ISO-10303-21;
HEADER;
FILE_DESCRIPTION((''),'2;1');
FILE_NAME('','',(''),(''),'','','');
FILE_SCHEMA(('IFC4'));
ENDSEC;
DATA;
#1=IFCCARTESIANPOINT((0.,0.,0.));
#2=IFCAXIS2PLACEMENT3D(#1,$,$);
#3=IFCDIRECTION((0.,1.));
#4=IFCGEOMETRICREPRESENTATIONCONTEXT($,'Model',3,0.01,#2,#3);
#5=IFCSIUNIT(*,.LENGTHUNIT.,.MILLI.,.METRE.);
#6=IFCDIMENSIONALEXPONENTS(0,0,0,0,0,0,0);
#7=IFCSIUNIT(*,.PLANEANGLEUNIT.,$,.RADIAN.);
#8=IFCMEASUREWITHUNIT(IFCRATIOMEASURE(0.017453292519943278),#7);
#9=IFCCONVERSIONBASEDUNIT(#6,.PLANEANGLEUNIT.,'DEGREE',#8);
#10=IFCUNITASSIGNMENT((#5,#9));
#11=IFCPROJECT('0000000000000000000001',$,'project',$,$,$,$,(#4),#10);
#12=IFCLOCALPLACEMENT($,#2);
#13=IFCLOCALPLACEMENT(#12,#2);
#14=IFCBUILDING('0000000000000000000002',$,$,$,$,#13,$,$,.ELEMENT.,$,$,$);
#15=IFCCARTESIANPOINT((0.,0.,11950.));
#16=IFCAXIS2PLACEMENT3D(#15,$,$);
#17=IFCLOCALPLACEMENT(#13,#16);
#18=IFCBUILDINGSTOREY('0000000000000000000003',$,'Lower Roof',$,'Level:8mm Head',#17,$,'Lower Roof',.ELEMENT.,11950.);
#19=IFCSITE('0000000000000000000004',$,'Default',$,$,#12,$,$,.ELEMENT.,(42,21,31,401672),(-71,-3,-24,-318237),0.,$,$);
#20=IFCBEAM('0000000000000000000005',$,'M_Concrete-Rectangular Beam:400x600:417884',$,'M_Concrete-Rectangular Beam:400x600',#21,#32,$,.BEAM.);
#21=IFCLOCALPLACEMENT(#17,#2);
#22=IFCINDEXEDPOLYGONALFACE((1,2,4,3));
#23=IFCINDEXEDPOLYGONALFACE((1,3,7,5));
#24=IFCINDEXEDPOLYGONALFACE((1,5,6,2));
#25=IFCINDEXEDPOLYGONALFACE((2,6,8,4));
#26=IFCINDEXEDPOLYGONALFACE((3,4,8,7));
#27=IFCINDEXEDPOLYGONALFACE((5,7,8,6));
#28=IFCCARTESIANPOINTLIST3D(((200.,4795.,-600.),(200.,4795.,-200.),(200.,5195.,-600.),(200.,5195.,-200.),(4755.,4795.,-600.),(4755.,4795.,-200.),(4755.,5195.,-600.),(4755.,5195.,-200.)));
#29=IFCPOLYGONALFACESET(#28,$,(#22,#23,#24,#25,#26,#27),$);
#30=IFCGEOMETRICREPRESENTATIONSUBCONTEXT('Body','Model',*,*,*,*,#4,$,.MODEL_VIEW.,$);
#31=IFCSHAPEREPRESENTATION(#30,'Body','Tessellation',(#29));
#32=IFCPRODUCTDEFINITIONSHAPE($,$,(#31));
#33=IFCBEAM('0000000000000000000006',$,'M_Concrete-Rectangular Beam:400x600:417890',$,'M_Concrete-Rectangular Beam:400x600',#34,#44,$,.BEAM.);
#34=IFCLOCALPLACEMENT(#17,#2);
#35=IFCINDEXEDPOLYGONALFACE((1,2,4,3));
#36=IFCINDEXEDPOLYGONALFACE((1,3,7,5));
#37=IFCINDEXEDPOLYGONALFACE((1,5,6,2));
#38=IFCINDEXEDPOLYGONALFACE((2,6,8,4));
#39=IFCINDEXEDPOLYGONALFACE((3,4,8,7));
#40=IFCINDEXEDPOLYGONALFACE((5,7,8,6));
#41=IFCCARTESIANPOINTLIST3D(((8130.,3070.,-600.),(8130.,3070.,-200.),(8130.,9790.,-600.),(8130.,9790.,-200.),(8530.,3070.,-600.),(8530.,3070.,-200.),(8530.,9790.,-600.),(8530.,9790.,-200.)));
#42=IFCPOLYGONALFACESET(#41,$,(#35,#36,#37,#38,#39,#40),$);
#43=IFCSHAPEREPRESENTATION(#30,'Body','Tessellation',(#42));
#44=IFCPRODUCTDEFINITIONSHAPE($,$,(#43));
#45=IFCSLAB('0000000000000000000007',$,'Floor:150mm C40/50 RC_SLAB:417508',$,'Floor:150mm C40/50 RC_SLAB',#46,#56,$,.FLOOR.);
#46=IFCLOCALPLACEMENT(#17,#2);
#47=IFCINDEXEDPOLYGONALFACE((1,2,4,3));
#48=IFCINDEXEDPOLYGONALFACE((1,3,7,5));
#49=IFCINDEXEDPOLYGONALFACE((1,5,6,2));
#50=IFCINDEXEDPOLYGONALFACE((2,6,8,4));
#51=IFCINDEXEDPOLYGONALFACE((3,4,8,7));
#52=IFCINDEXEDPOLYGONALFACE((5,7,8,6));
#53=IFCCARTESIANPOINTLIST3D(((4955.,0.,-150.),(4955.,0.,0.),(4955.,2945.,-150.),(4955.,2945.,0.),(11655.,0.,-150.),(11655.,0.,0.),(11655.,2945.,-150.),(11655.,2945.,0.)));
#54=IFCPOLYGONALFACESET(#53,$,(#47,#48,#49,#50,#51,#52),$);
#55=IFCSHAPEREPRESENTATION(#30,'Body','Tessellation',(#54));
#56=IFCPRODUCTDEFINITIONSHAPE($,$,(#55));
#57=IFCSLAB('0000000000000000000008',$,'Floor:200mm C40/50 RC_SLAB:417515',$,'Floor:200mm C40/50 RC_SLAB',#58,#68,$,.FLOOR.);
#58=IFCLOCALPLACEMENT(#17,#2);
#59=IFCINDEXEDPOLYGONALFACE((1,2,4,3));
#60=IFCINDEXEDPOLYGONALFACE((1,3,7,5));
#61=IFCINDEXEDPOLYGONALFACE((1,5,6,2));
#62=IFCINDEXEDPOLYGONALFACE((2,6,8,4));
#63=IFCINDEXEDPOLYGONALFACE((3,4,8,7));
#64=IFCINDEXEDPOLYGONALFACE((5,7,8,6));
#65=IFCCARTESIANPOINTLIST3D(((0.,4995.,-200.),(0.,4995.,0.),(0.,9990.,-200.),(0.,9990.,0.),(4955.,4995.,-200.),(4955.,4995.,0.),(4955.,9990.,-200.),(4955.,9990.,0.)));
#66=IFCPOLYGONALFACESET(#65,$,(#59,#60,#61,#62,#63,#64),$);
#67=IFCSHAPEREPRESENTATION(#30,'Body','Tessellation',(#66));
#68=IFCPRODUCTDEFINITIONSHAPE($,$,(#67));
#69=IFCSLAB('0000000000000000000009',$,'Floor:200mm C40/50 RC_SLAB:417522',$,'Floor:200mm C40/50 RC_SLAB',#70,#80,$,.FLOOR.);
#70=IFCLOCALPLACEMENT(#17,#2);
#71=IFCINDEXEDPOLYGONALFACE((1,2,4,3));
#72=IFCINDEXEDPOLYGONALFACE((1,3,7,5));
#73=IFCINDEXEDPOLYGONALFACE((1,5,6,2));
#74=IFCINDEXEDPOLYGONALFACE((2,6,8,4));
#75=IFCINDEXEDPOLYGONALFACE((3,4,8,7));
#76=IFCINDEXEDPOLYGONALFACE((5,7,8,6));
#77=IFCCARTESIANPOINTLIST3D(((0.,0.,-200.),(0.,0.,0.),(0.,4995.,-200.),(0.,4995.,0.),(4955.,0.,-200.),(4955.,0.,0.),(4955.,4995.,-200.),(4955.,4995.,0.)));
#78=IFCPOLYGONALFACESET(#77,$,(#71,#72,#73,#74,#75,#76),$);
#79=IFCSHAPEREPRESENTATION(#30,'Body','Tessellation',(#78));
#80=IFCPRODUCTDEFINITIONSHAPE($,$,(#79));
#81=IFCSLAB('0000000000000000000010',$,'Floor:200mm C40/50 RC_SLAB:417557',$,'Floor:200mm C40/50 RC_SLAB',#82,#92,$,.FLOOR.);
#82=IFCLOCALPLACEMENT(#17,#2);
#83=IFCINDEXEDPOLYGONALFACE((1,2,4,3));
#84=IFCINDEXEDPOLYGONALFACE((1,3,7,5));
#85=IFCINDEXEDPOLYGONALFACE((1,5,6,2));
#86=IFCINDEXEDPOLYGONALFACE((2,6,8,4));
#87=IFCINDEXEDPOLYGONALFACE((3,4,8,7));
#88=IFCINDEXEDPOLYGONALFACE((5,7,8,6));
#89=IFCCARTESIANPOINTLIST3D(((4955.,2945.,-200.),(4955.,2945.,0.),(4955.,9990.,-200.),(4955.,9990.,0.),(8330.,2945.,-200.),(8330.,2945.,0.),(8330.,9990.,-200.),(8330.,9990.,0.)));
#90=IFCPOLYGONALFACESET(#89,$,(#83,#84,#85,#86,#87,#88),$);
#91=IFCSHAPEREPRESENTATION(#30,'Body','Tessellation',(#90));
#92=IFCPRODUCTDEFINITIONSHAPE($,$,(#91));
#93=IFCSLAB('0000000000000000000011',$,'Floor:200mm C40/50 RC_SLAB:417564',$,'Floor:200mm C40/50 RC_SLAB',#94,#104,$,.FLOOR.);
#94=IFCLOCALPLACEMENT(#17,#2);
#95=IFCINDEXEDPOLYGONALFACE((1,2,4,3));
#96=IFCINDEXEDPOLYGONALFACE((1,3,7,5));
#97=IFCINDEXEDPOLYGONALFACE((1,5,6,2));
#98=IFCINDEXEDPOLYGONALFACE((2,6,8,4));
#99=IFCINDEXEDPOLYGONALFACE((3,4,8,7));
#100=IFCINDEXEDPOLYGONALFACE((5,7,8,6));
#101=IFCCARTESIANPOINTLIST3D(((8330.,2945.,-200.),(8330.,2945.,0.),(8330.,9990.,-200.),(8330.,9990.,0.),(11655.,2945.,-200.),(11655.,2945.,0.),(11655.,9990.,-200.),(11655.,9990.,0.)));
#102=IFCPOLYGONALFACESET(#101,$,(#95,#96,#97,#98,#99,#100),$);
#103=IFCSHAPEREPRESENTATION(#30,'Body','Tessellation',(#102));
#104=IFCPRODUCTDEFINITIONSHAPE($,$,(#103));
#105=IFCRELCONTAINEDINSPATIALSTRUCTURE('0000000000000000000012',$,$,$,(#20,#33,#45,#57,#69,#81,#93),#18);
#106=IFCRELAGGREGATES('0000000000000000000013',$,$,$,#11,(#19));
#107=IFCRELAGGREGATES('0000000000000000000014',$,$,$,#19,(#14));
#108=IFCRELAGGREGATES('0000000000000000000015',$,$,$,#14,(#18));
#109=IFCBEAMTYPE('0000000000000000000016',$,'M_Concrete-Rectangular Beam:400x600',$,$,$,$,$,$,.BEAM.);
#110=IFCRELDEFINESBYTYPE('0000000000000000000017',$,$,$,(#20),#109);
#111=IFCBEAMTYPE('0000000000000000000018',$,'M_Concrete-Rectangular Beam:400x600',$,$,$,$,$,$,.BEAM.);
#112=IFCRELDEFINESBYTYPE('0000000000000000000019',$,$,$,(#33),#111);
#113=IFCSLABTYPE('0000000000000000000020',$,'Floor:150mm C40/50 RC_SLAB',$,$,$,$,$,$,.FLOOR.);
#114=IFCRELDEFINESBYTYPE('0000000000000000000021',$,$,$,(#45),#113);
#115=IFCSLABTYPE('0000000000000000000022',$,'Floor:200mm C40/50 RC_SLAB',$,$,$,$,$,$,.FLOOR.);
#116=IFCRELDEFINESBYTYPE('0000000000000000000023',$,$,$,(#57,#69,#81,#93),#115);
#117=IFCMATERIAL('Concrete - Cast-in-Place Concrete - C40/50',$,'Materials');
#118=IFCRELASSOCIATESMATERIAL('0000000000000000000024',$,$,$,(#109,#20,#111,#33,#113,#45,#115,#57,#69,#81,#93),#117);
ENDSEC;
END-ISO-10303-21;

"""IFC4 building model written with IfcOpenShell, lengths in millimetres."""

from ifc_helpers import new_model, entity, si_unit, converted_unit, direction, frame, origin, place, context, subcontext, project, spatial, indexed_curve, outline, extrude, source, transform, mapped, material, type_object, type_shapes, element, save


model = new_model("IFC4")

# Units and contexts
model_context = context("Model", 3, precision=0.01, world=origin(), true_north=direction((0.0, 1.0)))
body_context = subcontext(model_context, "Body", "Model", "MODEL_VIEW")
ifc_project = project(units=[si_unit("LENGTHUNIT", "METRE", prefix="MILLI"), converted_unit("PLANEANGLEUNIT", "DEGREE", entity("IfcRatioMeasure", 0.017453292519943278), si_unit("PLANEANGLEUNIT", "RADIAN"), dimensions=[0, 0, 0, 0, 0, 0, 0])], contexts=[model_context])

# Site, building, storey
site_placement = place(None, origin())
site = spatial("IfcSite", under=ifc_project, at=site_placement, Name="Default", CompositionType="ELEMENT", RefLatitude=(42, 21, 31, 401672), RefLongitude=(-71, -3, -24, -318237), RefElevation=0.0)
building_placement = place(site_placement, origin())
building = spatial("IfcBuilding", under=site, at=building_placement, CompositionType="ELEMENT")
storey_placement = place(building_placement, frame((0.0, 0.0, 11950.0)))
storey = spatial("IfcBuildingStorey", under=building, at=storey_placement, Name="Lower Roof", ObjectType="Level:8mm Head", LongName="Lower Roof", CompositionType="ELEMENT", Elevation=11950.0)

# Beams
ifc_material = material(Name="Concrete - Cast-in-Place Concrete - C40/50", Category="Materials")
beam_type_1 = type_object("IfcBeamType", Name="M_Concrete-Rectangular Beam:400x600", PredefinedType="BEAM", material=ifc_material)
shared_shape_1 = source(origin(), body_context, "Body", "SweptSolid", [
    extrude(outline(indexed_curve([(-200.0, -200.0), (200.0, -200.0), (200.0, 200.0), (-200.0, 200.0), (-200.0, -200.0)], self_intersect=False)), frame((200.0, 4995.0, 11550.0), z_axis=(1.0, 0.0, 0.0), x_axis=(0.0, 0.0, -1.0)), (0.0, 0.0, 1.0), 4555.0),
])
type_shapes(beam_type_1, [shared_shape_1])
beam_1_placement = place(storey_placement, frame((0.0, 0.0, -11950.0)))
element("IfcBeam", 1, at=beam_1_placement, inside=storey, type_object=beam_type_1, material=ifc_material, Name="M_Concrete-Rectangular Beam:400x600:417884", ObjectType="M_Concrete-Rectangular Beam:400x600", PredefinedType="BEAM", context=body_context, shape_type="MappedRepresentation", body=[
    mapped(shared_shape_1, transform((0.0, 0.0, 0.0), scale=1.0)),
])
beam_type_2 = type_object("IfcBeamType", Name="M_Concrete-Rectangular Beam:400x600", PredefinedType="BEAM", material=ifc_material)
shared_shape_2 = source(origin(), body_context, "Body", "SweptSolid", [
    extrude(outline(indexed_curve([(-200.0, -200.0), (200.0, -200.0), (200.0, 200.0), (-200.0, 200.0), (-200.0, -200.0)], self_intersect=False)), frame((8330.0, 3070.0, 11550.0), z_axis=(0.0, 1.0, 0.0), x_axis=(-1.0, 0.0, 0.0)), (0.0, 0.0, 1.0), 6720.0),
])
type_shapes(beam_type_2, [shared_shape_2])
beam_2_placement = place(storey_placement, frame((0.0, 0.0, -11950.0)))
element("IfcBeam", 2, at=beam_2_placement, inside=storey, type_object=beam_type_2, material=ifc_material, Name="M_Concrete-Rectangular Beam:400x600:417890", ObjectType="M_Concrete-Rectangular Beam:400x600", PredefinedType="BEAM", context=body_context, shape_type="MappedRepresentation", body=[
    mapped(shared_shape_2, transform((0.0, 0.0, 0.0), scale=1.0)),
])

# Slabs
slab_type_1 = type_object("IfcSlabType", Name="Floor:150mm C40/50 RC_SLAB", PredefinedType="FLOOR", material=ifc_material)
slab_1_placement = place(storey_placement, origin())
element("IfcSlab", 3, at=slab_1_placement, inside=storey, type_object=slab_type_1, material=ifc_material, Name="Floor:150mm C40/50 RC_SLAB:417508", ObjectType="Floor:150mm C40/50 RC_SLAB", PredefinedType="FLOOR", context=body_context, shape_type="SweptSolid", body=[
    extrude(outline(indexed_curve([(-1472.5, -3350.0), (1472.5, -3350.0), (1472.5, 3350.0), (-1472.5, 3350.0), (-1472.5, -3350.0)], self_intersect=False)), frame((8305.0, 1472.5, 0.0), z_axis=(0.0, 0.0, -1.0), x_axis=(0.0, 1.0, 0.0)), (0.0, 0.0, 1.0), 150.0),
])
slab_type_2 = type_object("IfcSlabType", Name="Floor:200mm C40/50 RC_SLAB", PredefinedType="FLOOR", material=ifc_material)
slab_2_placement = place(storey_placement, origin())
element("IfcSlab", 4, at=slab_2_placement, inside=storey, type_object=slab_type_2, material=ifc_material, Name="Floor:200mm C40/50 RC_SLAB:417515", ObjectType="Floor:200mm C40/50 RC_SLAB", PredefinedType="FLOOR", context=body_context, shape_type="SweptSolid", body=[
    extrude(outline(indexed_curve([(-2497.5, -2477.5), (2497.5, -2477.5), (2497.5, 2477.5), (-2497.5, 2477.5), (-2497.5, -2477.5)], self_intersect=False)), frame((2477.5, 7492.5, 0.0), z_axis=(0.0, 0.0, -1.0), x_axis=(0.0, 1.0, 0.0)), (0.0, 0.0, 1.0), 200.0),
])
slab_3_placement = place(storey_placement, origin())
element("IfcSlab", 5, at=slab_3_placement, inside=storey, type_object=slab_type_2, material=ifc_material, Name="Floor:200mm C40/50 RC_SLAB:417522", ObjectType="Floor:200mm C40/50 RC_SLAB", PredefinedType="FLOOR", context=body_context, shape_type="SweptSolid", body=[
    extrude(outline(indexed_curve([(-2497.5, -2477.5), (2497.5, -2477.5), (2497.5, 2477.5), (-2497.5, 2477.5), (-2497.5, -2477.5)], self_intersect=False)), frame((2477.5, 2497.5, 0.0), z_axis=(0.0, 0.0, -1.0), x_axis=(0.0, 1.0, 0.0)), (0.0, 0.0, 1.0), 200.0),
])
slab_4_placement = place(storey_placement, origin())
element("IfcSlab", 6, at=slab_4_placement, inside=storey, type_object=slab_type_2, material=ifc_material, Name="Floor:200mm C40/50 RC_SLAB:417557", ObjectType="Floor:200mm C40/50 RC_SLAB", PredefinedType="FLOOR", context=body_context, shape_type="SweptSolid", body=[
    extrude(outline(indexed_curve([(-3522.5, -1687.5), (3522.5, -1687.5), (3522.5, 1687.5), (-3522.5, 1687.5), (-3522.5, -1687.5)], self_intersect=False)), frame((6642.5, 6467.5, 0.0), z_axis=(0.0, 0.0, -1.0), x_axis=(0.0, 1.0, 0.0)), (0.0, 0.0, 1.0), 200.0),
])
slab_5_placement = place(storey_placement, origin())
element("IfcSlab", 7, at=slab_5_placement, inside=storey, type_object=slab_type_2, material=ifc_material, Name="Floor:200mm C40/50 RC_SLAB:417564", ObjectType="Floor:200mm C40/50 RC_SLAB", PredefinedType="FLOOR", context=body_context, shape_type="SweptSolid", body=[
    extrude(outline(indexed_curve([(-3522.5, -1662.5), (3522.5, -1662.5), (3522.5, 1662.5), (-3522.5, 1662.5), (-3522.5, -1662.5)], self_intersect=False)), frame((9992.5, 6467.5, 0.0), z_axis=(0.0, 0.0, -1.0), x_axis=(0.0, 1.0, 0.0)), (0.0, 0.0, 1.0), 200.0),
])

save(model, "model.ifc")
